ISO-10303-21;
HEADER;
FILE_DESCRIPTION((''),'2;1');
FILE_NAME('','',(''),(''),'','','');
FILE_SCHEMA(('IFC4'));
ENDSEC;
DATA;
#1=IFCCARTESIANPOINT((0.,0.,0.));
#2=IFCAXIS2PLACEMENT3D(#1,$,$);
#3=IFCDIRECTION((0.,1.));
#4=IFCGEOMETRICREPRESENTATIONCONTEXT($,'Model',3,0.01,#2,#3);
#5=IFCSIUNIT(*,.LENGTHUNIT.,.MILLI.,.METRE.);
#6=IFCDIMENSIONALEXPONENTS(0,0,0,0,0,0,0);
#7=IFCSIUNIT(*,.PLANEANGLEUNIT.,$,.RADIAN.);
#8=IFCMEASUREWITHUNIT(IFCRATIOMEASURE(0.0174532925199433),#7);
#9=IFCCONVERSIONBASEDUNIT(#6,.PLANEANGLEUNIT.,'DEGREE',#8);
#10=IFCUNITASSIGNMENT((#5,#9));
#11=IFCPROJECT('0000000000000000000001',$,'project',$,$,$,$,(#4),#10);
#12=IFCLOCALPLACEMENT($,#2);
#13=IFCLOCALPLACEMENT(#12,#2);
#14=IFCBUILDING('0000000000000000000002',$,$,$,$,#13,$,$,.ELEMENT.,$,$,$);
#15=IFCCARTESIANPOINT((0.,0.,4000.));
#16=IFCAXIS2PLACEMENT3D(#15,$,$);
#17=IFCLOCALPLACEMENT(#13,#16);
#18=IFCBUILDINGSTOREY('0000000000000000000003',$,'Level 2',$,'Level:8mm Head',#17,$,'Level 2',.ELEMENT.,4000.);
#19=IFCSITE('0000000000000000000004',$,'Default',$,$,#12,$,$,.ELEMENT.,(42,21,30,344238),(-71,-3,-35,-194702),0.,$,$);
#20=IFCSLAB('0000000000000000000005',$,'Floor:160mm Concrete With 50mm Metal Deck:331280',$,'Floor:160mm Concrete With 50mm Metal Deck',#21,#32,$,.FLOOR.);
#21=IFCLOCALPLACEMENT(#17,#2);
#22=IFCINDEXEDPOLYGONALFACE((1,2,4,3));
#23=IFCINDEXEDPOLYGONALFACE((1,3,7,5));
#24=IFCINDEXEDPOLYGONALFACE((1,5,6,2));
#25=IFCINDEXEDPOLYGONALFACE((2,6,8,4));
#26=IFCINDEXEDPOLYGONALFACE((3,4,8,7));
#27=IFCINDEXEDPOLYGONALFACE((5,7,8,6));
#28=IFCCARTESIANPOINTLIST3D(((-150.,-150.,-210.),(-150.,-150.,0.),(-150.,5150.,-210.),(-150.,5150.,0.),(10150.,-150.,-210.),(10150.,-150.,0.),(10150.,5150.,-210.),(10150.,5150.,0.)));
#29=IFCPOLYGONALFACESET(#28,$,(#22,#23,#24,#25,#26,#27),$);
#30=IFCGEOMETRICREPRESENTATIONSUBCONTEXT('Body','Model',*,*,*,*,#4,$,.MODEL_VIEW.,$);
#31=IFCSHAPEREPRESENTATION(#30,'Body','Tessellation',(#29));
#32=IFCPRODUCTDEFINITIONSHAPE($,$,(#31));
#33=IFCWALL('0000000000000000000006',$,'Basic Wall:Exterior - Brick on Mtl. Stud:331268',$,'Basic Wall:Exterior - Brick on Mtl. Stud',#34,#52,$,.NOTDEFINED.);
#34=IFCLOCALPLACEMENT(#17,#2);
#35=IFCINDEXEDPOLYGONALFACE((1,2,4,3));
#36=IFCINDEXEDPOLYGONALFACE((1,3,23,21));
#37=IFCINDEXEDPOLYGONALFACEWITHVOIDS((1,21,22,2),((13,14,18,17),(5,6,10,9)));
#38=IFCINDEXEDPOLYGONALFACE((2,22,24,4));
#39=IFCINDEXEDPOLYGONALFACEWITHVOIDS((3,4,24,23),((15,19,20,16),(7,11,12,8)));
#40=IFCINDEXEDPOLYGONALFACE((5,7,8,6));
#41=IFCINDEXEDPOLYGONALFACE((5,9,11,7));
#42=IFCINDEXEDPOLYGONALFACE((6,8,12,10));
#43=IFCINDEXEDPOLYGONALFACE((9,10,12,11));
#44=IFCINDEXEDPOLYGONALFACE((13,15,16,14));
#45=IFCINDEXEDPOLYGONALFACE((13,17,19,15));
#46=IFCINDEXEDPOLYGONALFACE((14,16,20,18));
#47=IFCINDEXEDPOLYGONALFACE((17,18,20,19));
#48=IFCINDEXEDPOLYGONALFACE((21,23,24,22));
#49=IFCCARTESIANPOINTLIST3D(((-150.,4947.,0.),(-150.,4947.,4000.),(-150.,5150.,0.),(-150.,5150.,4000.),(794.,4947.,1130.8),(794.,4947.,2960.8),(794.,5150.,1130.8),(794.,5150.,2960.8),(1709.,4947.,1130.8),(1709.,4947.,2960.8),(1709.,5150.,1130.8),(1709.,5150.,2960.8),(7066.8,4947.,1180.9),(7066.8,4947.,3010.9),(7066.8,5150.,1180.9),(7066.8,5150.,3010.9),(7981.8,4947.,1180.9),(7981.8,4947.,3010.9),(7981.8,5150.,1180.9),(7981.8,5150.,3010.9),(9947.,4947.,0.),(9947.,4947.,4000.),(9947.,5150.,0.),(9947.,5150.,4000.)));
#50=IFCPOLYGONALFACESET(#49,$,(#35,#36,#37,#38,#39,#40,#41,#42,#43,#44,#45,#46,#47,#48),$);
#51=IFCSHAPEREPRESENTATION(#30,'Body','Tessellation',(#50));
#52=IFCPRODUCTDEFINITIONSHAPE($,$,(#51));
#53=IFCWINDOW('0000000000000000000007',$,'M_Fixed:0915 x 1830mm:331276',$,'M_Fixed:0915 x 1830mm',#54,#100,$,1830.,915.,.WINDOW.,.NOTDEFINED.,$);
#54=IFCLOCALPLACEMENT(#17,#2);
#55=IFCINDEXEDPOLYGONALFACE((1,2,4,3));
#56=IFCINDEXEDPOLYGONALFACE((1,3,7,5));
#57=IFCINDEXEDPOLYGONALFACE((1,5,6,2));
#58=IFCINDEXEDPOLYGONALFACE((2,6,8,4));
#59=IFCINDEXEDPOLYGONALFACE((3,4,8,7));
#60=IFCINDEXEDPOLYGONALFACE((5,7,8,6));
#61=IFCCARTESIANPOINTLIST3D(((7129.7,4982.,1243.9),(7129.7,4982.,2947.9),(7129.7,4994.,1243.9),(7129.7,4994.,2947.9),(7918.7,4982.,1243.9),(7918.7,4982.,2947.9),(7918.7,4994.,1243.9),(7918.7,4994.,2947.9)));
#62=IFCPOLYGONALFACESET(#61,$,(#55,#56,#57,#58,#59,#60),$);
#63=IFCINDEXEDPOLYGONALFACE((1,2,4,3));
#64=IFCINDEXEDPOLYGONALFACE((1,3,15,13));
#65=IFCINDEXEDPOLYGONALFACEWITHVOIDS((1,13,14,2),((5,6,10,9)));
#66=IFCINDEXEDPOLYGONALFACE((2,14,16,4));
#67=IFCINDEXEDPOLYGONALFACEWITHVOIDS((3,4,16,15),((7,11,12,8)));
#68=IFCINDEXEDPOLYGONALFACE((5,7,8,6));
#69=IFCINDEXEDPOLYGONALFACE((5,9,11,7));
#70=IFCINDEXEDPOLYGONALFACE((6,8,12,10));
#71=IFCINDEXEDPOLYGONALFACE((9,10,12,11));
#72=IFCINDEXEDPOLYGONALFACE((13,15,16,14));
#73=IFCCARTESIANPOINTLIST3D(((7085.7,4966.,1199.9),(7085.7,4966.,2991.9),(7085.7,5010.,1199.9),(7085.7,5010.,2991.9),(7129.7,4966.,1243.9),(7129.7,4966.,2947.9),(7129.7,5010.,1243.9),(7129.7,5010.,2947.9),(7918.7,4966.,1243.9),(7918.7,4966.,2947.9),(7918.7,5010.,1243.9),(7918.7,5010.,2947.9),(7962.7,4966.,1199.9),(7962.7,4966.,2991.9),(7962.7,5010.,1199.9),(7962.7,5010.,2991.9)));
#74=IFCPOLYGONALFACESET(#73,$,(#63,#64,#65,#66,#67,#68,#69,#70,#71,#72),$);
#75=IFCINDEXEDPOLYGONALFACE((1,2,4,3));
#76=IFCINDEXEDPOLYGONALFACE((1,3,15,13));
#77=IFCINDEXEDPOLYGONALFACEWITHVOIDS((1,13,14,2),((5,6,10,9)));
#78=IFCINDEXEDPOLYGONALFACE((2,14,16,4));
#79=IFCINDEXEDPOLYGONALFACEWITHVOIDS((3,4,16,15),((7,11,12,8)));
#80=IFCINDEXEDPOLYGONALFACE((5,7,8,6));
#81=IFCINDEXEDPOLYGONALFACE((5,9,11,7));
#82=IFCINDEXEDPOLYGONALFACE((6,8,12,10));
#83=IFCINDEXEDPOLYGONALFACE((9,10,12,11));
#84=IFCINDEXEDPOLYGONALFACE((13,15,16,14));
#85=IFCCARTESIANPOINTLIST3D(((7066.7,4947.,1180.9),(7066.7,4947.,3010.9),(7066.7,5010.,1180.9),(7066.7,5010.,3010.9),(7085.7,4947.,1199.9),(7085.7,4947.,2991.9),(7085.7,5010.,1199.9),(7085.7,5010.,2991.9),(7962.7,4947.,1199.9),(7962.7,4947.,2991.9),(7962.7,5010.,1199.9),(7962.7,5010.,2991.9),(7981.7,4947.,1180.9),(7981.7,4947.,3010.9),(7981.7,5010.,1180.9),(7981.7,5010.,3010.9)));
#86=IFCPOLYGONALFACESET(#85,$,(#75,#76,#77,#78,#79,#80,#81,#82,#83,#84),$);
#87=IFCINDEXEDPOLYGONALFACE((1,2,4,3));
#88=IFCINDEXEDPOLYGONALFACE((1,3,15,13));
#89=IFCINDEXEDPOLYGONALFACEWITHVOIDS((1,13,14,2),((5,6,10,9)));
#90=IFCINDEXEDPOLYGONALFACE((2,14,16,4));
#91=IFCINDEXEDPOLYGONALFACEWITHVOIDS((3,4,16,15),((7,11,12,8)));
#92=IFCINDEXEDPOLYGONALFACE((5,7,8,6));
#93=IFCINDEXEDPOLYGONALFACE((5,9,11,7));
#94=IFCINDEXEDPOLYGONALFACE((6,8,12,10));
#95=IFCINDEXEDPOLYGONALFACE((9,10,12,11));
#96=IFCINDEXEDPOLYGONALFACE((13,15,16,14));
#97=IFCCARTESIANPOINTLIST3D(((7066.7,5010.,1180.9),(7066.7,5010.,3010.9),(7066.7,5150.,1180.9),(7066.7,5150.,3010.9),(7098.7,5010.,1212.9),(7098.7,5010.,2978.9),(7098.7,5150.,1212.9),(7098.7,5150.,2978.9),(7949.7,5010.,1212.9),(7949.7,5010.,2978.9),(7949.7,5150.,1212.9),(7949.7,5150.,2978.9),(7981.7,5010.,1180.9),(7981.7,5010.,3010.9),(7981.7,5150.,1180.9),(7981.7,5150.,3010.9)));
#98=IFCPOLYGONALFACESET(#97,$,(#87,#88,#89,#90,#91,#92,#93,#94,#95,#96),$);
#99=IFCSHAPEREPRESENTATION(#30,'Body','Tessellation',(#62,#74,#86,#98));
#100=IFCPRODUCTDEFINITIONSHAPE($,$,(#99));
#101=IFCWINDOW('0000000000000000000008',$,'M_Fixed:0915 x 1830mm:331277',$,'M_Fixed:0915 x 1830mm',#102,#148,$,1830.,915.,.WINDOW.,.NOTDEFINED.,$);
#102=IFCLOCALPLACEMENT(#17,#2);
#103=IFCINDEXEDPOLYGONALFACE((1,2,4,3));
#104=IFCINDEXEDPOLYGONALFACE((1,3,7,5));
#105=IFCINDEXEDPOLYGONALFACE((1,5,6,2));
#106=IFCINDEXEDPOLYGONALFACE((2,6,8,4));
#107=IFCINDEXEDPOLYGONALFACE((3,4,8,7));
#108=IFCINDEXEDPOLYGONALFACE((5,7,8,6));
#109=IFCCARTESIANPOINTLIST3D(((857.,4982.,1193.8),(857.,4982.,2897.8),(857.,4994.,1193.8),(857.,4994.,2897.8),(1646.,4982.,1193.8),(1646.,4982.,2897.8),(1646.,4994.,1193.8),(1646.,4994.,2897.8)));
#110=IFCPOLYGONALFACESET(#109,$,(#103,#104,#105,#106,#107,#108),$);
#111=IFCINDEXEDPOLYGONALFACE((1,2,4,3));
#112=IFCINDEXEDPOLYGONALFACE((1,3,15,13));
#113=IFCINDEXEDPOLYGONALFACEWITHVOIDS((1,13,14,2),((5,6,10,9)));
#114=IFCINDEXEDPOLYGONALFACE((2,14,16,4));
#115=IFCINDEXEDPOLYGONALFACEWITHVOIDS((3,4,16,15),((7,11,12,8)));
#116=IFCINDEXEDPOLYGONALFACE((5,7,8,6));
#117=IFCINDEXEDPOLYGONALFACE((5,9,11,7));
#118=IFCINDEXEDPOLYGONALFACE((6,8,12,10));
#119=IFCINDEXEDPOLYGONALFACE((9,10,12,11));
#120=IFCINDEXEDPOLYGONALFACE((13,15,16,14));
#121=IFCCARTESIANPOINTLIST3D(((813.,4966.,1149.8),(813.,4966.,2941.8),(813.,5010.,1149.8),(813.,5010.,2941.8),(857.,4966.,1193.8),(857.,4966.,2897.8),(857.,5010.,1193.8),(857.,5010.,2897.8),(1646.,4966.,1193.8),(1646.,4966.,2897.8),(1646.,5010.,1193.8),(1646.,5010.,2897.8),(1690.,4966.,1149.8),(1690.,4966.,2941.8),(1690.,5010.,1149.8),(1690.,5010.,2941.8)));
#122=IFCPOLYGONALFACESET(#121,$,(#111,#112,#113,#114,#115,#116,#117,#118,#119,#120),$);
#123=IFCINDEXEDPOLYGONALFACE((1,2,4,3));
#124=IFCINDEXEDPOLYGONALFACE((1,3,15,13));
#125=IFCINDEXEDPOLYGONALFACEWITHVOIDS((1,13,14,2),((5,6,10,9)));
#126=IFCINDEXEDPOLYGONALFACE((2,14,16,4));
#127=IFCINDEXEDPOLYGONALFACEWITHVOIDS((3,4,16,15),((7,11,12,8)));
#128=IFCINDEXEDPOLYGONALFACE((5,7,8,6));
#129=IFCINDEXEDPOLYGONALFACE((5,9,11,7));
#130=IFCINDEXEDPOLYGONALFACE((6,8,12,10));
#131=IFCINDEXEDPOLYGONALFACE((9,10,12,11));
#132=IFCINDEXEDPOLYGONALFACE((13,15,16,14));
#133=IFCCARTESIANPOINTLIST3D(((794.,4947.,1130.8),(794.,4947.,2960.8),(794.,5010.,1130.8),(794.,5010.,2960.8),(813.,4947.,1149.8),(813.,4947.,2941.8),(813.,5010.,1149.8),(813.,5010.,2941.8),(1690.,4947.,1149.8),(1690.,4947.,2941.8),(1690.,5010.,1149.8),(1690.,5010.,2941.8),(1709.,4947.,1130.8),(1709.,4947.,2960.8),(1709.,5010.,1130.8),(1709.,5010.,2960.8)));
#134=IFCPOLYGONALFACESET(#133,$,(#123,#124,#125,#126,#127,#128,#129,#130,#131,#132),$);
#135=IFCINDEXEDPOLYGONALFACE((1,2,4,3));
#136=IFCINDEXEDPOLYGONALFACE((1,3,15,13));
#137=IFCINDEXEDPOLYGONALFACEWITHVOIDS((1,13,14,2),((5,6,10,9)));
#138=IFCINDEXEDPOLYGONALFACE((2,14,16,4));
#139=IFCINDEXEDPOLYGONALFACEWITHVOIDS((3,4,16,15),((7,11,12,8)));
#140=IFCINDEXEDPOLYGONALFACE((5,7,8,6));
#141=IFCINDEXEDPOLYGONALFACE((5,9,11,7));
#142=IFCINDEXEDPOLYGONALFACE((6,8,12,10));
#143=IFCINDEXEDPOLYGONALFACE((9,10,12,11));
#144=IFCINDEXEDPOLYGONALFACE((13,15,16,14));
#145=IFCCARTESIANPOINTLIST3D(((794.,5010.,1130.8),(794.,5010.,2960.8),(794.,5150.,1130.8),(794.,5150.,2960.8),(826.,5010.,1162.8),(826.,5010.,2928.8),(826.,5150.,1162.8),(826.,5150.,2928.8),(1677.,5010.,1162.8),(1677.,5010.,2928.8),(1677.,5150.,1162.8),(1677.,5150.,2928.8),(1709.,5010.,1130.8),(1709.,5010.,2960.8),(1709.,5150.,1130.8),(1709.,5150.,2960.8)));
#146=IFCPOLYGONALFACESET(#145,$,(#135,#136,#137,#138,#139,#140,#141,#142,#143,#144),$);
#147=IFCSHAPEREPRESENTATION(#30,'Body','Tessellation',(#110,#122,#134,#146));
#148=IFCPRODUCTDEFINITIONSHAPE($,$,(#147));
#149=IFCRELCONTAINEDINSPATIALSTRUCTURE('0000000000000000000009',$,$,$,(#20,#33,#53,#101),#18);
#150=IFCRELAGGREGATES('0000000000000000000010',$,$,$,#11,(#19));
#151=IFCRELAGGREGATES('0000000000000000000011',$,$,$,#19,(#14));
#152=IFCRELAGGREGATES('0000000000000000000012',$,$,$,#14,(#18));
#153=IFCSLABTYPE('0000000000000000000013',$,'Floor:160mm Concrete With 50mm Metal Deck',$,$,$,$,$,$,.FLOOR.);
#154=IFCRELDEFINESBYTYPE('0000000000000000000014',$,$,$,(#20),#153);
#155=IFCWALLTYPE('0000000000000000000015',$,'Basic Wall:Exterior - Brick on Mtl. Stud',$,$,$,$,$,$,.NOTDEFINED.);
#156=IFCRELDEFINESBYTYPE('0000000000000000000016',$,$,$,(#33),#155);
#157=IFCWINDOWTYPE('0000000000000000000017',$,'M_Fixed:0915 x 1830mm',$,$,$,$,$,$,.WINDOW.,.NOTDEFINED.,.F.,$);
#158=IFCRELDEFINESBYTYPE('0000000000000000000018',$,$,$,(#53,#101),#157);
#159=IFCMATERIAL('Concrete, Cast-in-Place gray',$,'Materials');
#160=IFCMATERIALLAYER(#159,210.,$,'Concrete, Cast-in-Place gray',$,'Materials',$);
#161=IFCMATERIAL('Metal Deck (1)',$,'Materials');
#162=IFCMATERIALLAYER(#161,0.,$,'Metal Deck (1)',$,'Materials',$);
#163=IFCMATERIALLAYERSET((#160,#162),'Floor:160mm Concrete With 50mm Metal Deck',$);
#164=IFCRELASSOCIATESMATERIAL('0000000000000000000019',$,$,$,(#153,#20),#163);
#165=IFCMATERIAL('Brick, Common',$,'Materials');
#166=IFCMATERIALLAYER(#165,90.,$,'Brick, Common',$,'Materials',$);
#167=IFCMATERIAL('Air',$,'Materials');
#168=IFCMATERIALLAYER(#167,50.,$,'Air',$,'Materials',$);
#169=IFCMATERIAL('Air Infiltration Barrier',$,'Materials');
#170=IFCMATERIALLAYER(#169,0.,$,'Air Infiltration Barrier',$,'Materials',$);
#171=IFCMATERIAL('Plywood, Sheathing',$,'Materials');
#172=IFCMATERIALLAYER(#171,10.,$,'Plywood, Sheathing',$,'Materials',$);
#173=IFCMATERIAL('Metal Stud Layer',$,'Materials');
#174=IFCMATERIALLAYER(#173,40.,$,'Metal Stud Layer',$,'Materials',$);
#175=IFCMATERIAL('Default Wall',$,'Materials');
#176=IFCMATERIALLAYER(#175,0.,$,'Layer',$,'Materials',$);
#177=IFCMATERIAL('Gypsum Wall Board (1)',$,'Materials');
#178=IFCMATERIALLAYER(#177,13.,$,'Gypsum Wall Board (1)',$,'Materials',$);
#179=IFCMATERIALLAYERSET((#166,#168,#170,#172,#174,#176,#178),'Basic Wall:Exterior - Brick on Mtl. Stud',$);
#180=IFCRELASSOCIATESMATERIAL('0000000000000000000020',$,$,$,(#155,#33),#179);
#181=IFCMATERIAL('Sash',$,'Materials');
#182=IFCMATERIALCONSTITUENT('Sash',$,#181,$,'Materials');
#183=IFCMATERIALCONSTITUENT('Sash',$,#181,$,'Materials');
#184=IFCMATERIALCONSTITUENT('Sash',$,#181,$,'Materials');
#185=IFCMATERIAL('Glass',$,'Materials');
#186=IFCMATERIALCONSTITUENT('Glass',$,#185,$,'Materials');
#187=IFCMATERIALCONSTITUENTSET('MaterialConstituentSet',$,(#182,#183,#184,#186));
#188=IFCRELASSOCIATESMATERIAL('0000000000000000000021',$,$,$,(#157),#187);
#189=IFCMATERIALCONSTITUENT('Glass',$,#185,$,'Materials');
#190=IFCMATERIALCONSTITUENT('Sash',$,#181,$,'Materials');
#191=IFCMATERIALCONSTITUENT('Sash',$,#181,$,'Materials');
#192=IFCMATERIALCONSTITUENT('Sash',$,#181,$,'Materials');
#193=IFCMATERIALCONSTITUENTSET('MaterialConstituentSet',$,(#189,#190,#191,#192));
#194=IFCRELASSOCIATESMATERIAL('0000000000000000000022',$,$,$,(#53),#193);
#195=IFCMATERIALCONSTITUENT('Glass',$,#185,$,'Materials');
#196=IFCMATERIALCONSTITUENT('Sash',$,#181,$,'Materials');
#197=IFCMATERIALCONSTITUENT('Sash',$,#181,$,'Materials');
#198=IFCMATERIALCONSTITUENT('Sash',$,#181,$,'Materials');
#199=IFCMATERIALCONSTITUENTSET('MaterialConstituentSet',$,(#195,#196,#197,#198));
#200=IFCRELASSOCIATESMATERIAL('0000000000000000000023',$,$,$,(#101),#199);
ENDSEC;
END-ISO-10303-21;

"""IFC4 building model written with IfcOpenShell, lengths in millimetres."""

from ifc_helpers import new_model, entity, si_unit, converted_unit, direction, frame, frame_2d, origin, place, context, subcontext, project, spatial, polyline, rectangle, outline, extrude, source, transform, mapped, material, layer, layer_set, layer_usage, constituent, constituent_set, type_object, type_shapes, element, fill, save


model = new_model("IFC4")

# Units and contexts
model_context = context("Model", 3, precision=0.01, world=origin(), true_north=direction((0.0, 1.0)))
body_context = subcontext(model_context, "Body", "Model", "MODEL_VIEW")
ifc_project = project(units=[si_unit("LENGTHUNIT", "METRE", prefix="MILLI"), converted_unit("PLANEANGLEUNIT", "DEGREE", entity("IfcRatioMeasure", 0.0174532925199433), si_unit("PLANEANGLEUNIT", "RADIAN"), dimensions=[0, 0, 0, 0, 0, 0, 0])], contexts=[model_context])

# Site, building, storey
site_placement = place(None, origin())
site = spatial("IfcSite", under=ifc_project, at=site_placement, Name="Default", CompositionType="ELEMENT", RefLatitude=(42, 21, 30, 344238), RefLongitude=(-71, -3, -35, -194702), RefElevation=0.0)
building_placement = place(site_placement, origin())
building = spatial("IfcBuilding", under=site, at=building_placement, CompositionType="ELEMENT")
storey_placement = place(building_placement, frame((0.0, 0.0, 4000.0)))
storey = spatial("IfcBuildingStorey", under=building, at=storey_placement, Name="Level 2", ObjectType="Level:8mm Head", LongName="Level 2", CompositionType="ELEMENT", Elevation=4000.0)

# Slab
ifc_material_1 = material(Name="Concrete, Cast-in-Place gray", Category="Materials")
ifc_layer_1 = layer(ifc_material_1, 210.0, Name="Concrete, Cast-in-Place gray", Category="Materials")
ifc_material_2 = material(Name="Metal Deck (1)", Category="Materials")
ifc_layer_2 = layer(ifc_material_2, 0.0, Name="Metal Deck (1)", Category="Materials")
ifc_layer_set_1 = layer_set([ifc_layer_1, ifc_layer_2], Name="Floor:160mm Concrete With 50mm Metal Deck")
ifc_layer_usage_1 = layer_usage(ifc_layer_set_1, "AXIS3", "POSITIVE", 0.0)
slab_type = type_object("IfcSlabType", Name="Floor:160mm Concrete With 50mm Metal Deck", PredefinedType="FLOOR", material=ifc_layer_set_1)
slab_placement = place(storey_placement, origin())
element("IfcSlab", 1, at=slab_placement, inside=storey, type_object=slab_type, material=ifc_layer_usage_1, Name="Floor:160mm Concrete With 50mm Metal Deck:331280", ObjectType="Floor:160mm Concrete With 50mm Metal Deck", PredefinedType="FLOOR", context=body_context, shape_type="SweptSolid", body=[
    extrude(rectangle(XDim=5300.0, YDim=10300.0, at=frame_2d((0.0, 0.0), x_axis=(1.0, 0.0))), frame((5000.0, 2500.0, 0.0), z_axis=(0.0, 0.0, -1.0), x_axis=(0.0, 1.0, 0.0)), (0.0, 0.0, 1.0), 210.0),
])

# Wall, openings, windows
ifc_material_3 = material(Name="Brick, Common", Category="Materials")
ifc_layer_3 = layer(ifc_material_3, 90.0, Name="Brick, Common", Category="Materials")
ifc_material_4 = material(Name="Air", Category="Materials")
ifc_layer_4 = layer(ifc_material_4, 50.0, Name="Air", Category="Materials")
ifc_material_5 = material(Name="Air Infiltration Barrier", Category="Materials")
ifc_layer_5 = layer(ifc_material_5, 0.0, Name="Air Infiltration Barrier", Category="Materials")
ifc_material_6 = material(Name="Plywood, Sheathing", Category="Materials")
ifc_layer_6 = layer(ifc_material_6, 10.0, Name="Plywood, Sheathing", Category="Materials")
ifc_material_7 = material(Name="Metal Stud Layer", Category="Materials")
ifc_layer_7 = layer(ifc_material_7, 40.0, Name="Metal Stud Layer", Category="Materials")
ifc_material_8 = material(Name="Default Wall", Category="Materials")
ifc_layer_8 = layer(ifc_material_8, 0.0, Name="Layer", Category="Materials")
ifc_material_9 = material(Name="Gypsum Wall Board (1)", Category="Materials")
ifc_layer_9 = layer(ifc_material_9, 13.0, Name="Gypsum Wall Board (1)", Category="Materials")
ifc_layer_set_2 = layer_set([ifc_layer_3, ifc_layer_4, ifc_layer_5, ifc_layer_6, ifc_layer_7, ifc_layer_8, ifc_layer_9], Name="Basic Wall:Exterior - Brick on Mtl. Stud")
ifc_layer_usage_2 = layer_usage(ifc_layer_set_2, "AXIS2", "NEGATIVE", 101.5)
wall_type_1 = type_object("IfcWallType", Name="Basic Wall:Exterior - Brick on Mtl. Stud", PredefinedType="NOTDEFINED", material=ifc_layer_set_2)
wall_1_placement = place(storey_placement, frame((-150.0, 5048.5, 0.0)))
wall_1 = element("IfcWall", 2, at=wall_1_placement, inside=storey, type_object=wall_type_1, material=ifc_layer_usage_2, Name="Basic Wall:Exterior - Brick on Mtl. Stud:331268", ObjectType="Basic Wall:Exterior - Brick on Mtl. Stud", PredefinedType="NOTDEFINED", context=body_context, shape_type="SweptSolid", body=[
    extrude(rectangle(XDim=10097.0, YDim=203.0, at=frame_2d((5048.5, 0.0), x_axis=(-1.0, 0.0))), origin(), (0.0, 0.0, 1.0), 4000.0),
])
opening_1_placement = place(wall_1_placement, frame((8131.8, 101.5, 1180.9)))
opening_1 = element("IfcOpeningElement", 3, at=opening_1_placement, cuts=wall_1, ObjectType="Opening", PredefinedType="OPENING", context=body_context, shape_type="SweptSolid", body=[
    extrude(rectangle(XDim=1830.0, YDim=915.0, at=frame_2d((915.0, 457.5), x_axis=(1.0, 0.0))), frame((0.0, 0.0, 0.0), z_axis=(0.0, -1.0, 0.0), x_axis=(0.0, 0.0, 1.0)), (0.0, 0.0, 1.0), 203.0),
])
opening_2_placement = place(wall_1_placement, frame((1859.0, 101.5, 1130.8)))
opening_2 = element("IfcOpeningElement", 4, at=opening_2_placement, cuts=wall_1, ObjectType="Opening", PredefinedType="OPENING", context=body_context, shape_type="SweptSolid", body=[
    extrude(rectangle(XDim=1830.0, YDim=915.0, at=frame_2d((915.0, 457.5), x_axis=(1.0, 0.0))), frame((0.0, 0.0, 0.0), z_axis=(0.0, -1.0, 0.0), x_axis=(0.0, 0.0, 1.0)), (0.0, 0.0, 1.0), 203.0),
])
ifc_material_10 = material(Name="Glass", Category="Materials")
ifc_constituent_1 = constituent(ifc_material_10, Name="Glass", Category="Materials")
ifc_material_11 = material(Name="Sash", Category="Materials")
ifc_constituent_2 = constituent(ifc_material_11, Name="Sash", Category="Materials")
ifc_constituent_3 = constituent(ifc_material_11, Name="Sash", Category="Materials")
ifc_constituent_4 = constituent(ifc_material_11, Name="Sash", Category="Materials")
ifc_constituent_set_1 = constituent_set(constituents=[ifc_constituent_1, ifc_constituent_2, ifc_constituent_3, ifc_constituent_4], Name="MaterialConstituentSet")
ifc_constituent_5 = constituent(ifc_material_11, Name="Sash", Category="Materials")
ifc_constituent_6 = constituent(ifc_material_11, Name="Sash", Category="Materials")
ifc_constituent_7 = constituent(ifc_material_11, Name="Sash", Category="Materials")
ifc_constituent_8 = constituent(ifc_material_10, Name="Glass", Category="Materials")
ifc_constituent_set_2 = constituent_set(constituents=[ifc_constituent_5, ifc_constituent_6, ifc_constituent_7, ifc_constituent_8], Name="MaterialConstituentSet")
window_type = type_object("IfcWindowType", Name="M_Fixed:0915 x 1830mm", ParameterTakesPrecedence=False, PartitioningType="NOTDEFINED", PredefinedType="WINDOW", material=ifc_constituent_set_2)
shared_shape_1 = source(origin(), body_context, "Body", "SweptSolid", [
    extrude(rectangle(XDim=12.0, YDim=789.0, at=frame_2d((0.0, 0.0), x_axis=(1.0, 0.0))), frame((457.5, 162.0, 63.0), z_axis=(0.0, 0.0, 1.0), x_axis=(0.0, -1.0, 0.0)), (0.0, 0.0, 1.0), 1704.0),
    extrude(outline(polyline([(-438.5, -896.0), (438.5, -896.0), (438.5, 896.0), (-438.5, 896.0), (-438.5, -896.0)]), holes=[polyline([(-394.5, -852.0), (-394.5, 852.0), (394.5, 852.0), (394.5, -852.0), (-394.5, -852.0)])]), frame((457.5, 140.0, 915.0), z_axis=(0.0, 1.0, 0.0), x_axis=(1.0, 0.0, 0.0)), (0.0, 0.0, 1.0), 44.0),
    extrude(outline(polyline([(-457.5, -915.0), (457.5, -915.0), (457.5, 915.0), (-457.5, 915.0), (-457.5, -915.0)]), holes=[polyline([(-438.5, -896.0), (-438.5, 896.0), (438.5, 896.0), (438.5, -896.0), (-438.5, -896.0)])]), frame((457.5, 140.0, 915.0), z_axis=(0.0, 1.0, 0.0), x_axis=(1.0, 0.0, 0.0)), (0.0, 0.0, 1.0), 63.0),
    extrude(outline(polyline([(-457.5, -915.0), (457.5, -915.0), (457.5, 915.0), (-457.5, 915.0), (-457.5, -915.0)]), holes=[polyline([(-425.5, -883.0), (-425.5, 883.0), (425.5, 883.0), (425.5, -883.0), (-425.5, -883.0)])]), frame((457.5, 0.0, 915.0), z_axis=(0.0, 1.0, 0.0), x_axis=(1.0, 0.0, 0.0)), (0.0, 0.0, 1.0), 140.0),
])
type_shapes(window_type, [shared_shape_1])
window_1_placement = place(opening_1_placement, frame((0.0, 0.0, 0.0), z_axis=(0.0, 0.0, 1.0), x_axis=(-1.0, 0.0, 0.0)))
window_1 = element("IfcWindow", 5, at=window_1_placement, inside=storey, type_object=window_type, material=ifc_constituent_set_1, Name="M_Fixed:0915 x 1830mm:331276", ObjectType="M_Fixed:0915 x 1830mm", OverallHeight=1830.0, OverallWidth=915.0, PartitioningType="NOTDEFINED", PredefinedType="WINDOW", context=body_context, shape_type="MappedRepresentation", body=[
    mapped(shared_shape_1, transform((0.0, 0.0, 0.0), scale=1.0)),
])
fill(opening_1, window_1)
ifc_constituent_9 = constituent(ifc_material_10, Name="Glass", Category="Materials")
ifc_constituent_10 = constituent(ifc_material_11, Name="Sash", Category="Materials")
ifc_constituent_11 = constituent(ifc_material_11, Name="Sash", Category="Materials")
ifc_constituent_12 = constituent(ifc_material_11, Name="Sash", Category="Materials")
ifc_constituent_set_3 = constituent_set(constituents=[ifc_constituent_9, ifc_constituent_10, ifc_constituent_11, ifc_constituent_12], Name="MaterialConstituentSet")
window_2_placement = place(opening_2_placement, frame((0.0, 0.0, 0.0), z_axis=(0.0, 0.0, 1.0), x_axis=(-1.0, 0.0, 0.0)))
window_2 = element("IfcWindow", 6, at=window_2_placement, inside=storey, type_object=window_type, material=ifc_constituent_set_3, Name="M_Fixed:0915 x 1830mm:331277", ObjectType="M_Fixed:0915 x 1830mm", OverallHeight=1830.0, OverallWidth=915.0, PartitioningType="NOTDEFINED", PredefinedType="WINDOW", context=body_context, shape_type="MappedRepresentation", body=[
    mapped(shared_shape_1, transform((0.0, 0.0, 0.0), scale=1.0)),
])
fill(opening_2, window_2)

save(model, "model.ifc")
